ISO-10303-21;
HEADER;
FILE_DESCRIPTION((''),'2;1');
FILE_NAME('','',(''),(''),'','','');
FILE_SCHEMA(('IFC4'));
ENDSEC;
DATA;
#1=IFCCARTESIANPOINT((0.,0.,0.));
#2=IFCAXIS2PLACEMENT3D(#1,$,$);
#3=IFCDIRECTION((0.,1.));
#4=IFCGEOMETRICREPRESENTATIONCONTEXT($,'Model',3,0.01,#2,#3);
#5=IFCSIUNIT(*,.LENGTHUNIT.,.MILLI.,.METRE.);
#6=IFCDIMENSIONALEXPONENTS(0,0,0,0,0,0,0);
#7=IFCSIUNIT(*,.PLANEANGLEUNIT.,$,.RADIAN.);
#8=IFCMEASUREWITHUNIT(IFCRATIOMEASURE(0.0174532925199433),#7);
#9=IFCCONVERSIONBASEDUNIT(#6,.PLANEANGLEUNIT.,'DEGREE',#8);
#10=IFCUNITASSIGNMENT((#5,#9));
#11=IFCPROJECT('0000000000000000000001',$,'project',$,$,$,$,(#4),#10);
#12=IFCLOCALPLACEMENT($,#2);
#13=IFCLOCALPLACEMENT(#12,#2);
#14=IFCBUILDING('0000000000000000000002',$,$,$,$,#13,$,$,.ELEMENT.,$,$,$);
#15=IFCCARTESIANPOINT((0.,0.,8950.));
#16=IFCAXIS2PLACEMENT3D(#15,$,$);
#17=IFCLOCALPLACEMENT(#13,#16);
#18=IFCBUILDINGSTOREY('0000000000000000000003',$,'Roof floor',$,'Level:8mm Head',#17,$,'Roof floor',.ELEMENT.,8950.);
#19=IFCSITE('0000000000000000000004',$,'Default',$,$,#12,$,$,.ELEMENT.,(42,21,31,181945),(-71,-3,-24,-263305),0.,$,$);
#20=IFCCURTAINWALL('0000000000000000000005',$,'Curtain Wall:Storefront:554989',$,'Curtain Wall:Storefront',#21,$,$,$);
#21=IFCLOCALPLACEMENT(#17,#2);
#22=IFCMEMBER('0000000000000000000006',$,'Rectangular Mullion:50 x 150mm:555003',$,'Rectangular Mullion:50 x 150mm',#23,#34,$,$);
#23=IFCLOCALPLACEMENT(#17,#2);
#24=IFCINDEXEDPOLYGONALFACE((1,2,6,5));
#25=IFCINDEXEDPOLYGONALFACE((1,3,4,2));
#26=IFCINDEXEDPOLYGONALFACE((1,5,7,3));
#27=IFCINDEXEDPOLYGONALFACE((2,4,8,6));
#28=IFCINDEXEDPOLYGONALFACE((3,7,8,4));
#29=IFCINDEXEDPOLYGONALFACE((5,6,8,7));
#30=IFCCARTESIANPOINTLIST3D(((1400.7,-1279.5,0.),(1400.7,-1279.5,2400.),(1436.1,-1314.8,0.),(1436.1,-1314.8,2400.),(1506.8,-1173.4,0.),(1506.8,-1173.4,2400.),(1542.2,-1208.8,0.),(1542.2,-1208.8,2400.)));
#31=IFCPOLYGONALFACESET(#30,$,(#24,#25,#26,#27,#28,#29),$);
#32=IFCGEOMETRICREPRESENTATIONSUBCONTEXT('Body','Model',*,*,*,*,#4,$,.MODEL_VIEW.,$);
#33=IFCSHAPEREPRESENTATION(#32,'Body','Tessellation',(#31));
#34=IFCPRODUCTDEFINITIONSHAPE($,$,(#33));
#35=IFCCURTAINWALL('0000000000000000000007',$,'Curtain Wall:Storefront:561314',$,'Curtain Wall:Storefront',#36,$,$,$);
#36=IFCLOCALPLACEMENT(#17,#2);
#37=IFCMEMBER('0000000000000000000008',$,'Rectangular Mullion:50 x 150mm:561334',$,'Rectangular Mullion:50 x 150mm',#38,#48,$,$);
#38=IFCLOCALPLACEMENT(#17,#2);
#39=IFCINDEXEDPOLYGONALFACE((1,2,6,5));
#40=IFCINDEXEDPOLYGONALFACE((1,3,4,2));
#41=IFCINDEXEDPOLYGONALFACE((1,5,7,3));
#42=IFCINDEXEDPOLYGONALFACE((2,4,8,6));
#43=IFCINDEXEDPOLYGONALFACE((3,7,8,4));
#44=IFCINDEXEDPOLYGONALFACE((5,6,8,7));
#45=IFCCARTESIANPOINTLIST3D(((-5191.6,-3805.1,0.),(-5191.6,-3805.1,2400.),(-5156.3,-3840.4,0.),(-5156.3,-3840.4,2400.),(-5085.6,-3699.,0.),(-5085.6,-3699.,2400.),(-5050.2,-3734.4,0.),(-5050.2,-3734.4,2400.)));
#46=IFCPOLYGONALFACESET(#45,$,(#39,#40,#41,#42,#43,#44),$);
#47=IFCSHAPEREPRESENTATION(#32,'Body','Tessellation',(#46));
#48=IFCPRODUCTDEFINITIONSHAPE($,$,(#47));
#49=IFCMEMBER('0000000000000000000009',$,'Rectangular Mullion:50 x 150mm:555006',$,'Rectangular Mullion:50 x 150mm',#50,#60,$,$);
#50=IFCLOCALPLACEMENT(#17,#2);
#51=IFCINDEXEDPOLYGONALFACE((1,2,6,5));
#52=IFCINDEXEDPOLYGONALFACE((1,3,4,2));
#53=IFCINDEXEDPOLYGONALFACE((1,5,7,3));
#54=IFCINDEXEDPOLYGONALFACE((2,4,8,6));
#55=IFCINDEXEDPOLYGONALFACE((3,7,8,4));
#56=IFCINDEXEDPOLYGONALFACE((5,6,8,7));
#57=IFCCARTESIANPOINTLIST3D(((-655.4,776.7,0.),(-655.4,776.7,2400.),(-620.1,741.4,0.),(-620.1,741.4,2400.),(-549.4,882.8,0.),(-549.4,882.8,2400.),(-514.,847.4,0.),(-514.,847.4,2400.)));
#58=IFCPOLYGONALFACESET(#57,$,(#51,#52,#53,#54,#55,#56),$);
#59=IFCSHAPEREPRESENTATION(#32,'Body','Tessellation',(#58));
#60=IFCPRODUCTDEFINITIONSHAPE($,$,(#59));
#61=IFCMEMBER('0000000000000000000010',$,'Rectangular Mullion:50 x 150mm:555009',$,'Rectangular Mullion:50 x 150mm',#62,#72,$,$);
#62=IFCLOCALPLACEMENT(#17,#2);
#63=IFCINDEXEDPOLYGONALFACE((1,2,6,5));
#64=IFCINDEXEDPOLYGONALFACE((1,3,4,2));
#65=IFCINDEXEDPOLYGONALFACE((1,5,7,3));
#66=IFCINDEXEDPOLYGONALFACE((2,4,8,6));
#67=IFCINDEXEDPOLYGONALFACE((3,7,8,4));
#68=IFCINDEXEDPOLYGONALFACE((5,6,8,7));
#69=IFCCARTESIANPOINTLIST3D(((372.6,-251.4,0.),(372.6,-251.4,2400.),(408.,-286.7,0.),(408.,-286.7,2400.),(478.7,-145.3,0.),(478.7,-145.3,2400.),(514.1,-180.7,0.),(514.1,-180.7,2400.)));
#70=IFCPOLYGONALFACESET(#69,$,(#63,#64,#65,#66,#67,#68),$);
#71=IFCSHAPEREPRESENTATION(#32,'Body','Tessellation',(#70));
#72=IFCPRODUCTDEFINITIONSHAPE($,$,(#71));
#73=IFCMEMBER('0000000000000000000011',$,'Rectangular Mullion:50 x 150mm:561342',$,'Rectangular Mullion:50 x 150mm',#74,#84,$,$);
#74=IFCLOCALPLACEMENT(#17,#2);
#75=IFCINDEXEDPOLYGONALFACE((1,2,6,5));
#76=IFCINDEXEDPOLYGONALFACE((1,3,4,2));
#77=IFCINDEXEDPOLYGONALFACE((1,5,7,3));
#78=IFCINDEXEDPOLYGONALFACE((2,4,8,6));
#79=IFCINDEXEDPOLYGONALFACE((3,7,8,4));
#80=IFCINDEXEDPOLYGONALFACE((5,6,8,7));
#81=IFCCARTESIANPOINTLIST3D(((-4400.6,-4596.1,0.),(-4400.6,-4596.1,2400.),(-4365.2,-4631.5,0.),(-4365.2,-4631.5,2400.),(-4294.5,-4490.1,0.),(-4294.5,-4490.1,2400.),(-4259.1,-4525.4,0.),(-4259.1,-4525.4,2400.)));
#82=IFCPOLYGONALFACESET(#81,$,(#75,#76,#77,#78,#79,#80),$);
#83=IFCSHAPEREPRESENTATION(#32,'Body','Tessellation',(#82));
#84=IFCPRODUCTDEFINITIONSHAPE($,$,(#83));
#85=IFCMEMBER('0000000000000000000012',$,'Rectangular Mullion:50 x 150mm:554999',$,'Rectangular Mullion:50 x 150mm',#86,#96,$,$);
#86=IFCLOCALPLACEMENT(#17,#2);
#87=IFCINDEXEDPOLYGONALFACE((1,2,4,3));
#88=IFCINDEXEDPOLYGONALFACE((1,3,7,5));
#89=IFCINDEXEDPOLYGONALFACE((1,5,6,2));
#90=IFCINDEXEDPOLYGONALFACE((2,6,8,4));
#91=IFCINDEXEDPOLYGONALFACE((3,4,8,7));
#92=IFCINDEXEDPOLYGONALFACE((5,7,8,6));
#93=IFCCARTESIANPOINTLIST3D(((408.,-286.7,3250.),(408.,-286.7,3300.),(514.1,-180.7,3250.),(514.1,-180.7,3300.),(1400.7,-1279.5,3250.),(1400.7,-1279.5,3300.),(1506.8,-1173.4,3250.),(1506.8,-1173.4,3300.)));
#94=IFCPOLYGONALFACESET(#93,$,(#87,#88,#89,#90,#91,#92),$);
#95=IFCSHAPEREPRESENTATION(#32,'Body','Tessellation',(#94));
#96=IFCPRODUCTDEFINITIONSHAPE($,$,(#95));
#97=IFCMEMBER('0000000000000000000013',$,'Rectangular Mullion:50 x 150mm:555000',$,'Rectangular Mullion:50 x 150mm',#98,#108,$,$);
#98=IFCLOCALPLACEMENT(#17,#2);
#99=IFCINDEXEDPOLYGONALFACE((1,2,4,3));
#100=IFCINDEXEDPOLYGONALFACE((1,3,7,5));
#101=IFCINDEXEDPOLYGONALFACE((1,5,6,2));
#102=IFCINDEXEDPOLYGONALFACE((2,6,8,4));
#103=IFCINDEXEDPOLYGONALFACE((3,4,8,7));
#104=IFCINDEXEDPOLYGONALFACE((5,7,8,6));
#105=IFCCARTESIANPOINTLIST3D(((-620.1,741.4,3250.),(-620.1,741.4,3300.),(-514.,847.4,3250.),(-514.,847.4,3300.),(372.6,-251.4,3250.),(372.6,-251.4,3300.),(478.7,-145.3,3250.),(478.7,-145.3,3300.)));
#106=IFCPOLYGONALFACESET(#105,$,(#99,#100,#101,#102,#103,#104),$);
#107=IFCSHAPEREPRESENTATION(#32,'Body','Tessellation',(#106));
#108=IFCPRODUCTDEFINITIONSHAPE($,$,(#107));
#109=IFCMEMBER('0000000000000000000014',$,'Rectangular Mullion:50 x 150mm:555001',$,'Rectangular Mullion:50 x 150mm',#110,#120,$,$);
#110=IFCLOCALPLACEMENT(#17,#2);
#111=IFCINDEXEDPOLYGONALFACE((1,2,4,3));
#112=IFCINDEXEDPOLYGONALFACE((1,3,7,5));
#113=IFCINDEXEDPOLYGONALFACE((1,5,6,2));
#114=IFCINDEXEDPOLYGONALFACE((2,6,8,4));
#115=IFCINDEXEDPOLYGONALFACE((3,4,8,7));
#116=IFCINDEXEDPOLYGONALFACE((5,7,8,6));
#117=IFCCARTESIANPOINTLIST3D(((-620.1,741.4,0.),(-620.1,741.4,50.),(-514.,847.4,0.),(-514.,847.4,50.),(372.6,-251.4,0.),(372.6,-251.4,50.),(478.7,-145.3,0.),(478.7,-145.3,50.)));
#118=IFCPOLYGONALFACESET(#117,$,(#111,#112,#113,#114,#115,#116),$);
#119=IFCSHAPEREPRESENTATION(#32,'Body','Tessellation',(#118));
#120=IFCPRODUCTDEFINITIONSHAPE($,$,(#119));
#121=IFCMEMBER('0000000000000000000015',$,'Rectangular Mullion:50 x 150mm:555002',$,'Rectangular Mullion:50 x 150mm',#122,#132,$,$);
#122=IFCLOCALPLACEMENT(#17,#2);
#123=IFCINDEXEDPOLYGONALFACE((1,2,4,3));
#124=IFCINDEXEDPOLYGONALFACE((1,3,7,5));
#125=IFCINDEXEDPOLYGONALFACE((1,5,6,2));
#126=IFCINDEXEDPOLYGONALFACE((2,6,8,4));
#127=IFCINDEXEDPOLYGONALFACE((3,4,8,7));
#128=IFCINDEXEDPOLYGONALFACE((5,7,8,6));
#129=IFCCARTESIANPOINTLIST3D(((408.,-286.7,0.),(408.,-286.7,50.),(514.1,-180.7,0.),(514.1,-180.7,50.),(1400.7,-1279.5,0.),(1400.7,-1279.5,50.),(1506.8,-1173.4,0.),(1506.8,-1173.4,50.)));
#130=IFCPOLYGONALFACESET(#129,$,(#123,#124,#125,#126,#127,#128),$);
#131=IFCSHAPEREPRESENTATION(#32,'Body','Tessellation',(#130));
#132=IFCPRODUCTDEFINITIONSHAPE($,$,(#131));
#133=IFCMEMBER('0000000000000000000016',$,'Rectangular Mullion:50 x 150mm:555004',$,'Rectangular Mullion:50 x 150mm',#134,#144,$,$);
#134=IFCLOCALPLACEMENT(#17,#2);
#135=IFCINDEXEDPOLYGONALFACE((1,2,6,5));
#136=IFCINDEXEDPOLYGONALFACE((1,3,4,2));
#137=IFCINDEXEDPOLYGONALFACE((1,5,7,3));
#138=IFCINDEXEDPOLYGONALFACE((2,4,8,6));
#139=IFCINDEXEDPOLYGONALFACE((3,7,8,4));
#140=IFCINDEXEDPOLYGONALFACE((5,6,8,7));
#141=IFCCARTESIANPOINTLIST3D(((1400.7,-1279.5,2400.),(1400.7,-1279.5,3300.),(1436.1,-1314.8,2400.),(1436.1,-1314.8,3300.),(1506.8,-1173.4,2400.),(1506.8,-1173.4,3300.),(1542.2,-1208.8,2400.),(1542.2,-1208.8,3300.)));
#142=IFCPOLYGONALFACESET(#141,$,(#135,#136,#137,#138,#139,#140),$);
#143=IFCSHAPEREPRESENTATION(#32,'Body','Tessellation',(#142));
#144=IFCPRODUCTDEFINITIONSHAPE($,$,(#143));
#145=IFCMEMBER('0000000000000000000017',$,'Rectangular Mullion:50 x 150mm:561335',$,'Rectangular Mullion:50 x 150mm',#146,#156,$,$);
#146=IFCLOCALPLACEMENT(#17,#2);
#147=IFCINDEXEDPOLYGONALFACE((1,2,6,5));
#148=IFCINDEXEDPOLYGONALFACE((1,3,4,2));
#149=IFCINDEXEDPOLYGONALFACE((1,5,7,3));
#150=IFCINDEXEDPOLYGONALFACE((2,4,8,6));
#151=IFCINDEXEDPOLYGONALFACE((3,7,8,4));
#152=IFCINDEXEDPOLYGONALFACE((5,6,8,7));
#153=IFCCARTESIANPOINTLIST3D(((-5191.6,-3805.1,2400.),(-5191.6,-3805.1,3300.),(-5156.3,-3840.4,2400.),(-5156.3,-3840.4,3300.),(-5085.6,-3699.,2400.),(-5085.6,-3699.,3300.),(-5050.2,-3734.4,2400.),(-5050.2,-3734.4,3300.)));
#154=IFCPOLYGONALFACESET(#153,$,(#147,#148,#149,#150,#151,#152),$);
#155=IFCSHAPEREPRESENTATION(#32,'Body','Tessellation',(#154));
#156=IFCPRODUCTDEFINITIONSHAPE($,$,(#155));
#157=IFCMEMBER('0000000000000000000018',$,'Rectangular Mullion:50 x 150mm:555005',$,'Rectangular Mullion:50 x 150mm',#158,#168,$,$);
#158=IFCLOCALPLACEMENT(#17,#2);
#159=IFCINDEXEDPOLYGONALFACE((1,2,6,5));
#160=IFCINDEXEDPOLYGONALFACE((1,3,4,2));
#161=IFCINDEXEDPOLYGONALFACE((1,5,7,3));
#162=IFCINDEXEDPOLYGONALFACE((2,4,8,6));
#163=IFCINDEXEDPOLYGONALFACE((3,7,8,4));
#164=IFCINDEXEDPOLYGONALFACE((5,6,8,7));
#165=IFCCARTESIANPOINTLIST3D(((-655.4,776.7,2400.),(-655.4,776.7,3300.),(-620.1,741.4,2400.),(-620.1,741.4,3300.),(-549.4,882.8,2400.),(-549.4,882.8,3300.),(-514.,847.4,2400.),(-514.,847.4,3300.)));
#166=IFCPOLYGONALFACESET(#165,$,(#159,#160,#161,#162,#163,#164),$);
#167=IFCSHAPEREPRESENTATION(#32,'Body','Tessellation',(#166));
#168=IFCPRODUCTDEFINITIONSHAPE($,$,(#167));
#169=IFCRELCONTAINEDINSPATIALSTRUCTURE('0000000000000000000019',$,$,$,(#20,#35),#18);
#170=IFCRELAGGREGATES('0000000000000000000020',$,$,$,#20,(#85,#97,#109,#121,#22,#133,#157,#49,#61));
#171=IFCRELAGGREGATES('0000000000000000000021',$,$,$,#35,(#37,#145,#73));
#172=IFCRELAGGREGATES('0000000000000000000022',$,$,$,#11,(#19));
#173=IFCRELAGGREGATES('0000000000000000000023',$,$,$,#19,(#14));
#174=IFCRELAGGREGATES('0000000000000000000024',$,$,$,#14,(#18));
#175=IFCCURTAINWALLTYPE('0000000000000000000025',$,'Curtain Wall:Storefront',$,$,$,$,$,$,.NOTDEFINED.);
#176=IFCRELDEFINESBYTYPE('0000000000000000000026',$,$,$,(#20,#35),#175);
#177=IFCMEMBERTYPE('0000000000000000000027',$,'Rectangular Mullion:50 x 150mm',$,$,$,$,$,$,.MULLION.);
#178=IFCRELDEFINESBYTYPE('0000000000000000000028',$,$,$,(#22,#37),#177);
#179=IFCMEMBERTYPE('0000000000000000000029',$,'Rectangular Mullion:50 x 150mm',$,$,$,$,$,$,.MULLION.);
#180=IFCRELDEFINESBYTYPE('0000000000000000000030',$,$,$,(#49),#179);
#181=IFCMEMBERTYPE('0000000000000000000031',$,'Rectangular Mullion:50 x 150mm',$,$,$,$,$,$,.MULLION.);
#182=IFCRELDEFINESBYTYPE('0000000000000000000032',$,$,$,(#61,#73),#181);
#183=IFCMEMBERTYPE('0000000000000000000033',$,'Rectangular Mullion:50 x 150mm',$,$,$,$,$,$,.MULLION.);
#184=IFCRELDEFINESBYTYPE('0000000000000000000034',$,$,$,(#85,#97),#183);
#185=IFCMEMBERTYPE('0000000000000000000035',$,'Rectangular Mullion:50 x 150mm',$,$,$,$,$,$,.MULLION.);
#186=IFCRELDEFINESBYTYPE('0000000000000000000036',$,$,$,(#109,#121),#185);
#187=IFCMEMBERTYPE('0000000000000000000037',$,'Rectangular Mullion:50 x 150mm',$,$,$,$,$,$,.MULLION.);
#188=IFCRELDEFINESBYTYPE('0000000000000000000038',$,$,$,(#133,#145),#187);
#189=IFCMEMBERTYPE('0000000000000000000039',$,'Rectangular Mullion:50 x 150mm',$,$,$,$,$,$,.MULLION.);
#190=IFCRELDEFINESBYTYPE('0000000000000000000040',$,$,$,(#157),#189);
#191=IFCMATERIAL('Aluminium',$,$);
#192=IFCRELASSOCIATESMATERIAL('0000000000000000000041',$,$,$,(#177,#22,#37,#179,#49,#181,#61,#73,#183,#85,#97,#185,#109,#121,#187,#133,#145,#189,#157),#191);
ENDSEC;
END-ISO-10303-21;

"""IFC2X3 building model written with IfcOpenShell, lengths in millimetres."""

from ifc_helpers import new_model, entity, si_unit, converted_unit, direction, frame, origin, origin_2d_with_axis, place, context, subcontext, project, spatial, rectangle, extrude, source, transform, mapped, material, type_object, type_shapes, element, aggregate, save


model = new_model("IFC2X3")

# Units and contexts
model_context = context("Model", 3, precision=0.01, world=origin(), true_north=direction((0.0, 1.0)))
body_context = subcontext(model_context, "Body", "Model", "MODEL_VIEW")
ifc_project = project(units=[si_unit("LENGTHUNIT", "METRE", prefix="MILLI"), converted_unit("PLANEANGLEUNIT", "DEGREE", entity("IfcRatioMeasure", 0.0174532925199433), si_unit("PLANEANGLEUNIT", "RADIAN"), dimensions=[0, 0, 0, 0, 0, 0, 0])], contexts=[model_context])

# Site, building, storey
site_placement = place(None, origin())
site = spatial("IfcSite", under=ifc_project, at=site_placement, Name="Default", CompositionType="ELEMENT", RefLatitude=(42, 21, 31, 181945), RefLongitude=(-71, -3, -24, -263305), RefElevation=0.0)
building_placement = place(site_placement, origin())
building = spatial("IfcBuilding", under=site, at=building_placement, CompositionType="ELEMENT")
storey_placement = place(building_placement, frame((0.0, 0.0, 8950.0)))
storey = spatial("IfcBuildingStorey", under=building, at=storey_placement, Name="Roof floor", ObjectType="Level:8mm Head", LongName="Roof floor", CompositionType="ELEMENT", Elevation=8950.0)

# Curtain walls, members
curtain_wall_type = type_object("IfcCurtainWallType", Name="Curtain Wall:Storefront", PredefinedType="NOTDEFINED")
curtain_wall_1_placement = place(storey_placement, frame((0.0, 0.0, -8950.0)))
curtain_wall_1 = element("IfcCurtainWall", 1, at=curtain_wall_1_placement, inside=storey, type_object=curtain_wall_type, Name="Curtain Wall:Storefront:554989", ObjectType="Curtain Wall:Storefront")
ifc_material_1 = material(Name="Aluminium")
member_type_1 = type_object("IfcMemberType", Name="Rectangular Mullion:50 x 150mm", PredefinedType="MULLION", material=ifc_material_1)
shared_shape_1 = source(origin(), body_context, "Body", "SweptSolid", [
    extrude(rectangle(XDim=150.0, YDim=50.0, at=origin_2d_with_axis()), frame((-25.0, 0.0, -2400.0), z_axis=(0.0, 0.0, 1.0), x_axis=(0.0, -1.0, 0.0)), (0.0, 0.0, 1.0), 2400.0),
])
type_shapes(member_type_1, [shared_shape_1])
member_1_placement = place(storey_placement, frame((1489.1, -1261.8, 0.0), z_axis=(0.0, 0.0, -1.0), x_axis=(0.707107, -0.707107, 0.0)))
member_1 = element("IfcMember", 2, at=member_1_placement, type_object=member_type_1, material=ifc_material_1, Name="Rectangular Mullion:50 x 150mm:555003", ObjectType="Rectangular Mullion:50 x 150mm", context=body_context, shape_type="MappedRepresentation", body=[
    mapped(shared_shape_1, transform((0.0, 0.0, 0.0), scale=1.0)),
])
curtain_wall_2_placement = place(storey_placement, frame((0.0, 0.0, -8950.0)))
curtain_wall_2 = element("IfcCurtainWall", 3, at=curtain_wall_2_placement, inside=storey, type_object=curtain_wall_type, Name="Curtain Wall:Storefront:561314", ObjectType="Curtain Wall:Storefront")
member_2_placement = place(storey_placement, frame((-5138.6, -3752.0, 0.0), z_axis=(0.0, 0.0, -1.0), x_axis=(-0.707107, 0.707107, 0.0)))
member_2 = element("IfcMember", 4, at=member_2_placement, type_object=member_type_1, material=ifc_material_1, Name="Rectangular Mullion:50 x 150mm:561334", ObjectType="Rectangular Mullion:50 x 150mm", context=body_context, shape_type="MappedRepresentation", body=[
    mapped(shared_shape_1, transform((0.0, 0.0, 0.0), scale=1.0)),
])

# Members
member_type_2 = type_object("IfcMemberType", Name="Rectangular Mullion:50 x 150mm", PredefinedType="MULLION", material=ifc_material_1)
shared_shape_2 = source(origin(), body_context, "Body", "SweptSolid", [
    extrude(rectangle(XDim=150.0, YDim=50.0, at=origin_2d_with_axis()), frame((-25.0, 0.0, -2400.0), z_axis=(0.0, 0.0, 1.0), x_axis=(0.0, -1.0, 0.0)), (0.0, 0.0, 1.0), 2400.0),
])
type_shapes(member_type_2, [shared_shape_2])
member_3_placement = place(storey_placement, frame((-602.4, 829.8, 2400.0), z_axis=(0.0, 0.0, 1.0), x_axis=(-0.707107, 0.707107, 0.0)))
member_3 = element("IfcMember", 5, at=member_3_placement, type_object=member_type_2, material=ifc_material_1, Name="Rectangular Mullion:50 x 150mm:555006", ObjectType="Rectangular Mullion:50 x 150mm", context=body_context, shape_type="MappedRepresentation", body=[
    mapped(shared_shape_2, transform((0.0, 0.0, 0.0), scale=1.0)),
])
member_type_3 = type_object("IfcMemberType", Name="Rectangular Mullion:50 x 150mm", PredefinedType="MULLION", material=ifc_material_1)
shared_shape_3 = source(origin(), body_context, "Body", "SweptSolid", [
    extrude(rectangle(XDim=150.0, YDim=50.0, at=origin_2d_with_axis()), frame((0.0, 0.0, -2400.0), z_axis=(0.0, 0.0, 1.0), x_axis=(0.0, -1.0, 0.0)), (0.0, 0.0, 1.0), 2400.0),
])
type_shapes(member_type_3, [shared_shape_3])
member_4_placement = place(storey_placement, frame((443.4, -216.0, 0.0), z_axis=(0.0, 0.0, -1.0), x_axis=(0.707107, -0.707107, 0.0)))
member_4 = element("IfcMember", 6, at=member_4_placement, type_object=member_type_3, material=ifc_material_1, Name="Rectangular Mullion:50 x 150mm:555009", ObjectType="Rectangular Mullion:50 x 150mm", context=body_context, shape_type="MappedRepresentation", body=[
    mapped(shared_shape_3, transform((0.0, 0.0, 0.0), scale=1.0)),
])
member_5_placement = place(storey_placement, frame((-4329.9, -4560.8, 0.0), z_axis=(0.0, 0.0, -1.0), x_axis=(-0.707107, 0.707107, 0.0)))
member_5 = element("IfcMember", 7, at=member_5_placement, type_object=member_type_3, material=ifc_material_1, Name="Rectangular Mullion:50 x 150mm:561342", ObjectType="Rectangular Mullion:50 x 150mm", context=body_context, shape_type="MappedRepresentation", body=[
    mapped(shared_shape_3, transform((0.0, 0.0, 0.0), scale=1.0)),
])
member_type_4 = type_object("IfcMemberType", Name="Rectangular Mullion:50 x 150mm", PredefinedType="MULLION", material=ifc_material_1)
shared_shape_4 = source(origin(), body_context, "Body", "SweptSolid", [
    extrude(rectangle(XDim=150.0, YDim=50.0, at=origin_2d_with_axis()), frame((-25.0, 0.0, -1403.9), z_axis=(0.0, 0.0, 1.0), x_axis=(0.0, -1.0, 0.0)), (0.0, 0.0, 1.0), 1403.9),
])
type_shapes(member_type_4, [shared_shape_4])
member_6_placement = place(storey_placement, frame((1453.8, -1226.4, 3300.0), z_axis=(0.707107, -0.707107, 0.0), x_axis=(0.0, 0.0, 1.0)))
member_6 = element("IfcMember", 8, at=member_6_placement, type_object=member_type_4, material=ifc_material_1, Name="Rectangular Mullion:50 x 150mm:554999", ObjectType="Rectangular Mullion:50 x 150mm", context=body_context, shape_type="MappedRepresentation", body=[
    mapped(shared_shape_4, transform((0.0, 0.0, 0.0), scale=1.0)),
])
member_7_placement = place(storey_placement, frame((425.7, -198.3, 3300.0), z_axis=(0.707107, -0.707107, 0.0), x_axis=(0.0, 0.0, 1.0)))
member_7 = element("IfcMember", 9, at=member_7_placement, type_object=member_type_4, material=ifc_material_1, Name="Rectangular Mullion:50 x 150mm:555000", ObjectType="Rectangular Mullion:50 x 150mm", context=body_context, shape_type="MappedRepresentation", body=[
    mapped(shared_shape_4, transform((0.0, 0.0, 0.0), scale=1.0)),
])
member_type_5 = type_object("IfcMemberType", Name="Rectangular Mullion:50 x 150mm", PredefinedType="MULLION", material=ifc_material_1)
shared_shape_5 = source(origin(), body_context, "Body", "SweptSolid", [
    extrude(rectangle(XDim=150.0, YDim=50.0, at=origin_2d_with_axis()), frame((-25.0, 0.0, -1403.9), z_axis=(0.0, 0.0, 1.0), x_axis=(0.0, -1.0, 0.0)), (0.0, 0.0, 1.0), 1403.9),
])
type_shapes(member_type_5, [shared_shape_5])
member_8_placement = place(storey_placement, frame((-567.1, 794.4, 0.0), z_axis=(-0.707107, 0.707107, 0.0), x_axis=(0.0, 0.0, -1.0)))
member_8 = element("IfcMember", 10, at=member_8_placement, type_object=member_type_5, material=ifc_material_1, Name="Rectangular Mullion:50 x 150mm:555001", ObjectType="Rectangular Mullion:50 x 150mm", context=body_context, shape_type="MappedRepresentation", body=[
    mapped(shared_shape_5, transform((0.0, 0.0, 0.0), scale=1.0)),
])
member_9_placement = place(storey_placement, frame((461.0, -233.7, 0.0), z_axis=(-0.707107, 0.707107, 0.0), x_axis=(0.0, 0.0, -1.0)))
member_9 = element("IfcMember", 11, at=member_9_placement, type_object=member_type_5, material=ifc_material_1, Name="Rectangular Mullion:50 x 150mm:555002", ObjectType="Rectangular Mullion:50 x 150mm", context=body_context, shape_type="MappedRepresentation", body=[
    mapped(shared_shape_5, transform((0.0, 0.0, 0.0), scale=1.0)),
])
member_type_6 = type_object("IfcMemberType", Name="Rectangular Mullion:50 x 150mm", PredefinedType="MULLION", material=ifc_material_1)
shared_shape_6 = source(origin(), body_context, "Body", "SweptSolid", [
    extrude(rectangle(XDim=150.0, YDim=50.0, at=origin_2d_with_axis()), frame((-25.0, 0.0, -900.0), z_axis=(0.0, 0.0, 1.0), x_axis=(0.0, -1.0, 0.0)), (0.0, 0.0, 1.0), 900.0),
])
type_shapes(member_type_6, [shared_shape_6])
member_10_placement = place(storey_placement, frame((1489.1, -1261.8, 2400.0), z_axis=(0.0, 0.0, -1.0), x_axis=(0.707107, -0.707107, 0.0)))
member_10 = element("IfcMember", 12, at=member_10_placement, type_object=member_type_6, material=ifc_material_1, Name="Rectangular Mullion:50 x 150mm:555004", ObjectType="Rectangular Mullion:50 x 150mm", context=body_context, shape_type="MappedRepresentation", body=[
    mapped(shared_shape_6, transform((0.0, 0.0, 0.0), scale=1.0)),
])
member_11_placement = place(storey_placement, frame((-5138.6, -3752.0, 2400.0), z_axis=(0.0, 0.0, -1.0), x_axis=(-0.707107, 0.707107, 0.0)))
member_11 = element("IfcMember", 13, at=member_11_placement, type_object=member_type_6, material=ifc_material_1, Name="Rectangular Mullion:50 x 150mm:561335", ObjectType="Rectangular Mullion:50 x 150mm", context=body_context, shape_type="MappedRepresentation", body=[
    mapped(shared_shape_6, transform((0.0, 0.0, 0.0), scale=1.0)),
])
member_type_7 = type_object("IfcMemberType", Name="Rectangular Mullion:50 x 150mm", PredefinedType="MULLION", material=ifc_material_1)
shared_shape_7 = source(origin(), body_context, "Body", "SweptSolid", [
    extrude(rectangle(XDim=150.0, YDim=50.0, at=origin_2d_with_axis()), frame((-25.0, 0.0, -900.0), z_axis=(0.0, 0.0, 1.0), x_axis=(0.0, -1.0, 0.0)), (0.0, 0.0, 1.0), 900.0),
])
type_shapes(member_type_7, [shared_shape_7])
member_12_placement = place(storey_placement, frame((-602.4, 829.8, 3300.0), z_axis=(0.0, 0.0, 1.0), x_axis=(-0.707107, 0.707107, 0.0)))
member_12 = element("IfcMember", 14, at=member_12_placement, type_object=member_type_7, material=ifc_material_1, Name="Rectangular Mullion:50 x 150mm:555005", ObjectType="Rectangular Mullion:50 x 150mm", context=body_context, shape_type="MappedRepresentation", body=[
    mapped(shared_shape_7, transform((0.0, 0.0, 0.0), scale=1.0)),
])

aggregate(curtain_wall_1, [member_6, member_7, member_8, member_9, member_1, member_10, member_12, member_3, member_4])
aggregate(curtain_wall_2, [member_2, member_11, member_5])

save(model, "model.ifc")
